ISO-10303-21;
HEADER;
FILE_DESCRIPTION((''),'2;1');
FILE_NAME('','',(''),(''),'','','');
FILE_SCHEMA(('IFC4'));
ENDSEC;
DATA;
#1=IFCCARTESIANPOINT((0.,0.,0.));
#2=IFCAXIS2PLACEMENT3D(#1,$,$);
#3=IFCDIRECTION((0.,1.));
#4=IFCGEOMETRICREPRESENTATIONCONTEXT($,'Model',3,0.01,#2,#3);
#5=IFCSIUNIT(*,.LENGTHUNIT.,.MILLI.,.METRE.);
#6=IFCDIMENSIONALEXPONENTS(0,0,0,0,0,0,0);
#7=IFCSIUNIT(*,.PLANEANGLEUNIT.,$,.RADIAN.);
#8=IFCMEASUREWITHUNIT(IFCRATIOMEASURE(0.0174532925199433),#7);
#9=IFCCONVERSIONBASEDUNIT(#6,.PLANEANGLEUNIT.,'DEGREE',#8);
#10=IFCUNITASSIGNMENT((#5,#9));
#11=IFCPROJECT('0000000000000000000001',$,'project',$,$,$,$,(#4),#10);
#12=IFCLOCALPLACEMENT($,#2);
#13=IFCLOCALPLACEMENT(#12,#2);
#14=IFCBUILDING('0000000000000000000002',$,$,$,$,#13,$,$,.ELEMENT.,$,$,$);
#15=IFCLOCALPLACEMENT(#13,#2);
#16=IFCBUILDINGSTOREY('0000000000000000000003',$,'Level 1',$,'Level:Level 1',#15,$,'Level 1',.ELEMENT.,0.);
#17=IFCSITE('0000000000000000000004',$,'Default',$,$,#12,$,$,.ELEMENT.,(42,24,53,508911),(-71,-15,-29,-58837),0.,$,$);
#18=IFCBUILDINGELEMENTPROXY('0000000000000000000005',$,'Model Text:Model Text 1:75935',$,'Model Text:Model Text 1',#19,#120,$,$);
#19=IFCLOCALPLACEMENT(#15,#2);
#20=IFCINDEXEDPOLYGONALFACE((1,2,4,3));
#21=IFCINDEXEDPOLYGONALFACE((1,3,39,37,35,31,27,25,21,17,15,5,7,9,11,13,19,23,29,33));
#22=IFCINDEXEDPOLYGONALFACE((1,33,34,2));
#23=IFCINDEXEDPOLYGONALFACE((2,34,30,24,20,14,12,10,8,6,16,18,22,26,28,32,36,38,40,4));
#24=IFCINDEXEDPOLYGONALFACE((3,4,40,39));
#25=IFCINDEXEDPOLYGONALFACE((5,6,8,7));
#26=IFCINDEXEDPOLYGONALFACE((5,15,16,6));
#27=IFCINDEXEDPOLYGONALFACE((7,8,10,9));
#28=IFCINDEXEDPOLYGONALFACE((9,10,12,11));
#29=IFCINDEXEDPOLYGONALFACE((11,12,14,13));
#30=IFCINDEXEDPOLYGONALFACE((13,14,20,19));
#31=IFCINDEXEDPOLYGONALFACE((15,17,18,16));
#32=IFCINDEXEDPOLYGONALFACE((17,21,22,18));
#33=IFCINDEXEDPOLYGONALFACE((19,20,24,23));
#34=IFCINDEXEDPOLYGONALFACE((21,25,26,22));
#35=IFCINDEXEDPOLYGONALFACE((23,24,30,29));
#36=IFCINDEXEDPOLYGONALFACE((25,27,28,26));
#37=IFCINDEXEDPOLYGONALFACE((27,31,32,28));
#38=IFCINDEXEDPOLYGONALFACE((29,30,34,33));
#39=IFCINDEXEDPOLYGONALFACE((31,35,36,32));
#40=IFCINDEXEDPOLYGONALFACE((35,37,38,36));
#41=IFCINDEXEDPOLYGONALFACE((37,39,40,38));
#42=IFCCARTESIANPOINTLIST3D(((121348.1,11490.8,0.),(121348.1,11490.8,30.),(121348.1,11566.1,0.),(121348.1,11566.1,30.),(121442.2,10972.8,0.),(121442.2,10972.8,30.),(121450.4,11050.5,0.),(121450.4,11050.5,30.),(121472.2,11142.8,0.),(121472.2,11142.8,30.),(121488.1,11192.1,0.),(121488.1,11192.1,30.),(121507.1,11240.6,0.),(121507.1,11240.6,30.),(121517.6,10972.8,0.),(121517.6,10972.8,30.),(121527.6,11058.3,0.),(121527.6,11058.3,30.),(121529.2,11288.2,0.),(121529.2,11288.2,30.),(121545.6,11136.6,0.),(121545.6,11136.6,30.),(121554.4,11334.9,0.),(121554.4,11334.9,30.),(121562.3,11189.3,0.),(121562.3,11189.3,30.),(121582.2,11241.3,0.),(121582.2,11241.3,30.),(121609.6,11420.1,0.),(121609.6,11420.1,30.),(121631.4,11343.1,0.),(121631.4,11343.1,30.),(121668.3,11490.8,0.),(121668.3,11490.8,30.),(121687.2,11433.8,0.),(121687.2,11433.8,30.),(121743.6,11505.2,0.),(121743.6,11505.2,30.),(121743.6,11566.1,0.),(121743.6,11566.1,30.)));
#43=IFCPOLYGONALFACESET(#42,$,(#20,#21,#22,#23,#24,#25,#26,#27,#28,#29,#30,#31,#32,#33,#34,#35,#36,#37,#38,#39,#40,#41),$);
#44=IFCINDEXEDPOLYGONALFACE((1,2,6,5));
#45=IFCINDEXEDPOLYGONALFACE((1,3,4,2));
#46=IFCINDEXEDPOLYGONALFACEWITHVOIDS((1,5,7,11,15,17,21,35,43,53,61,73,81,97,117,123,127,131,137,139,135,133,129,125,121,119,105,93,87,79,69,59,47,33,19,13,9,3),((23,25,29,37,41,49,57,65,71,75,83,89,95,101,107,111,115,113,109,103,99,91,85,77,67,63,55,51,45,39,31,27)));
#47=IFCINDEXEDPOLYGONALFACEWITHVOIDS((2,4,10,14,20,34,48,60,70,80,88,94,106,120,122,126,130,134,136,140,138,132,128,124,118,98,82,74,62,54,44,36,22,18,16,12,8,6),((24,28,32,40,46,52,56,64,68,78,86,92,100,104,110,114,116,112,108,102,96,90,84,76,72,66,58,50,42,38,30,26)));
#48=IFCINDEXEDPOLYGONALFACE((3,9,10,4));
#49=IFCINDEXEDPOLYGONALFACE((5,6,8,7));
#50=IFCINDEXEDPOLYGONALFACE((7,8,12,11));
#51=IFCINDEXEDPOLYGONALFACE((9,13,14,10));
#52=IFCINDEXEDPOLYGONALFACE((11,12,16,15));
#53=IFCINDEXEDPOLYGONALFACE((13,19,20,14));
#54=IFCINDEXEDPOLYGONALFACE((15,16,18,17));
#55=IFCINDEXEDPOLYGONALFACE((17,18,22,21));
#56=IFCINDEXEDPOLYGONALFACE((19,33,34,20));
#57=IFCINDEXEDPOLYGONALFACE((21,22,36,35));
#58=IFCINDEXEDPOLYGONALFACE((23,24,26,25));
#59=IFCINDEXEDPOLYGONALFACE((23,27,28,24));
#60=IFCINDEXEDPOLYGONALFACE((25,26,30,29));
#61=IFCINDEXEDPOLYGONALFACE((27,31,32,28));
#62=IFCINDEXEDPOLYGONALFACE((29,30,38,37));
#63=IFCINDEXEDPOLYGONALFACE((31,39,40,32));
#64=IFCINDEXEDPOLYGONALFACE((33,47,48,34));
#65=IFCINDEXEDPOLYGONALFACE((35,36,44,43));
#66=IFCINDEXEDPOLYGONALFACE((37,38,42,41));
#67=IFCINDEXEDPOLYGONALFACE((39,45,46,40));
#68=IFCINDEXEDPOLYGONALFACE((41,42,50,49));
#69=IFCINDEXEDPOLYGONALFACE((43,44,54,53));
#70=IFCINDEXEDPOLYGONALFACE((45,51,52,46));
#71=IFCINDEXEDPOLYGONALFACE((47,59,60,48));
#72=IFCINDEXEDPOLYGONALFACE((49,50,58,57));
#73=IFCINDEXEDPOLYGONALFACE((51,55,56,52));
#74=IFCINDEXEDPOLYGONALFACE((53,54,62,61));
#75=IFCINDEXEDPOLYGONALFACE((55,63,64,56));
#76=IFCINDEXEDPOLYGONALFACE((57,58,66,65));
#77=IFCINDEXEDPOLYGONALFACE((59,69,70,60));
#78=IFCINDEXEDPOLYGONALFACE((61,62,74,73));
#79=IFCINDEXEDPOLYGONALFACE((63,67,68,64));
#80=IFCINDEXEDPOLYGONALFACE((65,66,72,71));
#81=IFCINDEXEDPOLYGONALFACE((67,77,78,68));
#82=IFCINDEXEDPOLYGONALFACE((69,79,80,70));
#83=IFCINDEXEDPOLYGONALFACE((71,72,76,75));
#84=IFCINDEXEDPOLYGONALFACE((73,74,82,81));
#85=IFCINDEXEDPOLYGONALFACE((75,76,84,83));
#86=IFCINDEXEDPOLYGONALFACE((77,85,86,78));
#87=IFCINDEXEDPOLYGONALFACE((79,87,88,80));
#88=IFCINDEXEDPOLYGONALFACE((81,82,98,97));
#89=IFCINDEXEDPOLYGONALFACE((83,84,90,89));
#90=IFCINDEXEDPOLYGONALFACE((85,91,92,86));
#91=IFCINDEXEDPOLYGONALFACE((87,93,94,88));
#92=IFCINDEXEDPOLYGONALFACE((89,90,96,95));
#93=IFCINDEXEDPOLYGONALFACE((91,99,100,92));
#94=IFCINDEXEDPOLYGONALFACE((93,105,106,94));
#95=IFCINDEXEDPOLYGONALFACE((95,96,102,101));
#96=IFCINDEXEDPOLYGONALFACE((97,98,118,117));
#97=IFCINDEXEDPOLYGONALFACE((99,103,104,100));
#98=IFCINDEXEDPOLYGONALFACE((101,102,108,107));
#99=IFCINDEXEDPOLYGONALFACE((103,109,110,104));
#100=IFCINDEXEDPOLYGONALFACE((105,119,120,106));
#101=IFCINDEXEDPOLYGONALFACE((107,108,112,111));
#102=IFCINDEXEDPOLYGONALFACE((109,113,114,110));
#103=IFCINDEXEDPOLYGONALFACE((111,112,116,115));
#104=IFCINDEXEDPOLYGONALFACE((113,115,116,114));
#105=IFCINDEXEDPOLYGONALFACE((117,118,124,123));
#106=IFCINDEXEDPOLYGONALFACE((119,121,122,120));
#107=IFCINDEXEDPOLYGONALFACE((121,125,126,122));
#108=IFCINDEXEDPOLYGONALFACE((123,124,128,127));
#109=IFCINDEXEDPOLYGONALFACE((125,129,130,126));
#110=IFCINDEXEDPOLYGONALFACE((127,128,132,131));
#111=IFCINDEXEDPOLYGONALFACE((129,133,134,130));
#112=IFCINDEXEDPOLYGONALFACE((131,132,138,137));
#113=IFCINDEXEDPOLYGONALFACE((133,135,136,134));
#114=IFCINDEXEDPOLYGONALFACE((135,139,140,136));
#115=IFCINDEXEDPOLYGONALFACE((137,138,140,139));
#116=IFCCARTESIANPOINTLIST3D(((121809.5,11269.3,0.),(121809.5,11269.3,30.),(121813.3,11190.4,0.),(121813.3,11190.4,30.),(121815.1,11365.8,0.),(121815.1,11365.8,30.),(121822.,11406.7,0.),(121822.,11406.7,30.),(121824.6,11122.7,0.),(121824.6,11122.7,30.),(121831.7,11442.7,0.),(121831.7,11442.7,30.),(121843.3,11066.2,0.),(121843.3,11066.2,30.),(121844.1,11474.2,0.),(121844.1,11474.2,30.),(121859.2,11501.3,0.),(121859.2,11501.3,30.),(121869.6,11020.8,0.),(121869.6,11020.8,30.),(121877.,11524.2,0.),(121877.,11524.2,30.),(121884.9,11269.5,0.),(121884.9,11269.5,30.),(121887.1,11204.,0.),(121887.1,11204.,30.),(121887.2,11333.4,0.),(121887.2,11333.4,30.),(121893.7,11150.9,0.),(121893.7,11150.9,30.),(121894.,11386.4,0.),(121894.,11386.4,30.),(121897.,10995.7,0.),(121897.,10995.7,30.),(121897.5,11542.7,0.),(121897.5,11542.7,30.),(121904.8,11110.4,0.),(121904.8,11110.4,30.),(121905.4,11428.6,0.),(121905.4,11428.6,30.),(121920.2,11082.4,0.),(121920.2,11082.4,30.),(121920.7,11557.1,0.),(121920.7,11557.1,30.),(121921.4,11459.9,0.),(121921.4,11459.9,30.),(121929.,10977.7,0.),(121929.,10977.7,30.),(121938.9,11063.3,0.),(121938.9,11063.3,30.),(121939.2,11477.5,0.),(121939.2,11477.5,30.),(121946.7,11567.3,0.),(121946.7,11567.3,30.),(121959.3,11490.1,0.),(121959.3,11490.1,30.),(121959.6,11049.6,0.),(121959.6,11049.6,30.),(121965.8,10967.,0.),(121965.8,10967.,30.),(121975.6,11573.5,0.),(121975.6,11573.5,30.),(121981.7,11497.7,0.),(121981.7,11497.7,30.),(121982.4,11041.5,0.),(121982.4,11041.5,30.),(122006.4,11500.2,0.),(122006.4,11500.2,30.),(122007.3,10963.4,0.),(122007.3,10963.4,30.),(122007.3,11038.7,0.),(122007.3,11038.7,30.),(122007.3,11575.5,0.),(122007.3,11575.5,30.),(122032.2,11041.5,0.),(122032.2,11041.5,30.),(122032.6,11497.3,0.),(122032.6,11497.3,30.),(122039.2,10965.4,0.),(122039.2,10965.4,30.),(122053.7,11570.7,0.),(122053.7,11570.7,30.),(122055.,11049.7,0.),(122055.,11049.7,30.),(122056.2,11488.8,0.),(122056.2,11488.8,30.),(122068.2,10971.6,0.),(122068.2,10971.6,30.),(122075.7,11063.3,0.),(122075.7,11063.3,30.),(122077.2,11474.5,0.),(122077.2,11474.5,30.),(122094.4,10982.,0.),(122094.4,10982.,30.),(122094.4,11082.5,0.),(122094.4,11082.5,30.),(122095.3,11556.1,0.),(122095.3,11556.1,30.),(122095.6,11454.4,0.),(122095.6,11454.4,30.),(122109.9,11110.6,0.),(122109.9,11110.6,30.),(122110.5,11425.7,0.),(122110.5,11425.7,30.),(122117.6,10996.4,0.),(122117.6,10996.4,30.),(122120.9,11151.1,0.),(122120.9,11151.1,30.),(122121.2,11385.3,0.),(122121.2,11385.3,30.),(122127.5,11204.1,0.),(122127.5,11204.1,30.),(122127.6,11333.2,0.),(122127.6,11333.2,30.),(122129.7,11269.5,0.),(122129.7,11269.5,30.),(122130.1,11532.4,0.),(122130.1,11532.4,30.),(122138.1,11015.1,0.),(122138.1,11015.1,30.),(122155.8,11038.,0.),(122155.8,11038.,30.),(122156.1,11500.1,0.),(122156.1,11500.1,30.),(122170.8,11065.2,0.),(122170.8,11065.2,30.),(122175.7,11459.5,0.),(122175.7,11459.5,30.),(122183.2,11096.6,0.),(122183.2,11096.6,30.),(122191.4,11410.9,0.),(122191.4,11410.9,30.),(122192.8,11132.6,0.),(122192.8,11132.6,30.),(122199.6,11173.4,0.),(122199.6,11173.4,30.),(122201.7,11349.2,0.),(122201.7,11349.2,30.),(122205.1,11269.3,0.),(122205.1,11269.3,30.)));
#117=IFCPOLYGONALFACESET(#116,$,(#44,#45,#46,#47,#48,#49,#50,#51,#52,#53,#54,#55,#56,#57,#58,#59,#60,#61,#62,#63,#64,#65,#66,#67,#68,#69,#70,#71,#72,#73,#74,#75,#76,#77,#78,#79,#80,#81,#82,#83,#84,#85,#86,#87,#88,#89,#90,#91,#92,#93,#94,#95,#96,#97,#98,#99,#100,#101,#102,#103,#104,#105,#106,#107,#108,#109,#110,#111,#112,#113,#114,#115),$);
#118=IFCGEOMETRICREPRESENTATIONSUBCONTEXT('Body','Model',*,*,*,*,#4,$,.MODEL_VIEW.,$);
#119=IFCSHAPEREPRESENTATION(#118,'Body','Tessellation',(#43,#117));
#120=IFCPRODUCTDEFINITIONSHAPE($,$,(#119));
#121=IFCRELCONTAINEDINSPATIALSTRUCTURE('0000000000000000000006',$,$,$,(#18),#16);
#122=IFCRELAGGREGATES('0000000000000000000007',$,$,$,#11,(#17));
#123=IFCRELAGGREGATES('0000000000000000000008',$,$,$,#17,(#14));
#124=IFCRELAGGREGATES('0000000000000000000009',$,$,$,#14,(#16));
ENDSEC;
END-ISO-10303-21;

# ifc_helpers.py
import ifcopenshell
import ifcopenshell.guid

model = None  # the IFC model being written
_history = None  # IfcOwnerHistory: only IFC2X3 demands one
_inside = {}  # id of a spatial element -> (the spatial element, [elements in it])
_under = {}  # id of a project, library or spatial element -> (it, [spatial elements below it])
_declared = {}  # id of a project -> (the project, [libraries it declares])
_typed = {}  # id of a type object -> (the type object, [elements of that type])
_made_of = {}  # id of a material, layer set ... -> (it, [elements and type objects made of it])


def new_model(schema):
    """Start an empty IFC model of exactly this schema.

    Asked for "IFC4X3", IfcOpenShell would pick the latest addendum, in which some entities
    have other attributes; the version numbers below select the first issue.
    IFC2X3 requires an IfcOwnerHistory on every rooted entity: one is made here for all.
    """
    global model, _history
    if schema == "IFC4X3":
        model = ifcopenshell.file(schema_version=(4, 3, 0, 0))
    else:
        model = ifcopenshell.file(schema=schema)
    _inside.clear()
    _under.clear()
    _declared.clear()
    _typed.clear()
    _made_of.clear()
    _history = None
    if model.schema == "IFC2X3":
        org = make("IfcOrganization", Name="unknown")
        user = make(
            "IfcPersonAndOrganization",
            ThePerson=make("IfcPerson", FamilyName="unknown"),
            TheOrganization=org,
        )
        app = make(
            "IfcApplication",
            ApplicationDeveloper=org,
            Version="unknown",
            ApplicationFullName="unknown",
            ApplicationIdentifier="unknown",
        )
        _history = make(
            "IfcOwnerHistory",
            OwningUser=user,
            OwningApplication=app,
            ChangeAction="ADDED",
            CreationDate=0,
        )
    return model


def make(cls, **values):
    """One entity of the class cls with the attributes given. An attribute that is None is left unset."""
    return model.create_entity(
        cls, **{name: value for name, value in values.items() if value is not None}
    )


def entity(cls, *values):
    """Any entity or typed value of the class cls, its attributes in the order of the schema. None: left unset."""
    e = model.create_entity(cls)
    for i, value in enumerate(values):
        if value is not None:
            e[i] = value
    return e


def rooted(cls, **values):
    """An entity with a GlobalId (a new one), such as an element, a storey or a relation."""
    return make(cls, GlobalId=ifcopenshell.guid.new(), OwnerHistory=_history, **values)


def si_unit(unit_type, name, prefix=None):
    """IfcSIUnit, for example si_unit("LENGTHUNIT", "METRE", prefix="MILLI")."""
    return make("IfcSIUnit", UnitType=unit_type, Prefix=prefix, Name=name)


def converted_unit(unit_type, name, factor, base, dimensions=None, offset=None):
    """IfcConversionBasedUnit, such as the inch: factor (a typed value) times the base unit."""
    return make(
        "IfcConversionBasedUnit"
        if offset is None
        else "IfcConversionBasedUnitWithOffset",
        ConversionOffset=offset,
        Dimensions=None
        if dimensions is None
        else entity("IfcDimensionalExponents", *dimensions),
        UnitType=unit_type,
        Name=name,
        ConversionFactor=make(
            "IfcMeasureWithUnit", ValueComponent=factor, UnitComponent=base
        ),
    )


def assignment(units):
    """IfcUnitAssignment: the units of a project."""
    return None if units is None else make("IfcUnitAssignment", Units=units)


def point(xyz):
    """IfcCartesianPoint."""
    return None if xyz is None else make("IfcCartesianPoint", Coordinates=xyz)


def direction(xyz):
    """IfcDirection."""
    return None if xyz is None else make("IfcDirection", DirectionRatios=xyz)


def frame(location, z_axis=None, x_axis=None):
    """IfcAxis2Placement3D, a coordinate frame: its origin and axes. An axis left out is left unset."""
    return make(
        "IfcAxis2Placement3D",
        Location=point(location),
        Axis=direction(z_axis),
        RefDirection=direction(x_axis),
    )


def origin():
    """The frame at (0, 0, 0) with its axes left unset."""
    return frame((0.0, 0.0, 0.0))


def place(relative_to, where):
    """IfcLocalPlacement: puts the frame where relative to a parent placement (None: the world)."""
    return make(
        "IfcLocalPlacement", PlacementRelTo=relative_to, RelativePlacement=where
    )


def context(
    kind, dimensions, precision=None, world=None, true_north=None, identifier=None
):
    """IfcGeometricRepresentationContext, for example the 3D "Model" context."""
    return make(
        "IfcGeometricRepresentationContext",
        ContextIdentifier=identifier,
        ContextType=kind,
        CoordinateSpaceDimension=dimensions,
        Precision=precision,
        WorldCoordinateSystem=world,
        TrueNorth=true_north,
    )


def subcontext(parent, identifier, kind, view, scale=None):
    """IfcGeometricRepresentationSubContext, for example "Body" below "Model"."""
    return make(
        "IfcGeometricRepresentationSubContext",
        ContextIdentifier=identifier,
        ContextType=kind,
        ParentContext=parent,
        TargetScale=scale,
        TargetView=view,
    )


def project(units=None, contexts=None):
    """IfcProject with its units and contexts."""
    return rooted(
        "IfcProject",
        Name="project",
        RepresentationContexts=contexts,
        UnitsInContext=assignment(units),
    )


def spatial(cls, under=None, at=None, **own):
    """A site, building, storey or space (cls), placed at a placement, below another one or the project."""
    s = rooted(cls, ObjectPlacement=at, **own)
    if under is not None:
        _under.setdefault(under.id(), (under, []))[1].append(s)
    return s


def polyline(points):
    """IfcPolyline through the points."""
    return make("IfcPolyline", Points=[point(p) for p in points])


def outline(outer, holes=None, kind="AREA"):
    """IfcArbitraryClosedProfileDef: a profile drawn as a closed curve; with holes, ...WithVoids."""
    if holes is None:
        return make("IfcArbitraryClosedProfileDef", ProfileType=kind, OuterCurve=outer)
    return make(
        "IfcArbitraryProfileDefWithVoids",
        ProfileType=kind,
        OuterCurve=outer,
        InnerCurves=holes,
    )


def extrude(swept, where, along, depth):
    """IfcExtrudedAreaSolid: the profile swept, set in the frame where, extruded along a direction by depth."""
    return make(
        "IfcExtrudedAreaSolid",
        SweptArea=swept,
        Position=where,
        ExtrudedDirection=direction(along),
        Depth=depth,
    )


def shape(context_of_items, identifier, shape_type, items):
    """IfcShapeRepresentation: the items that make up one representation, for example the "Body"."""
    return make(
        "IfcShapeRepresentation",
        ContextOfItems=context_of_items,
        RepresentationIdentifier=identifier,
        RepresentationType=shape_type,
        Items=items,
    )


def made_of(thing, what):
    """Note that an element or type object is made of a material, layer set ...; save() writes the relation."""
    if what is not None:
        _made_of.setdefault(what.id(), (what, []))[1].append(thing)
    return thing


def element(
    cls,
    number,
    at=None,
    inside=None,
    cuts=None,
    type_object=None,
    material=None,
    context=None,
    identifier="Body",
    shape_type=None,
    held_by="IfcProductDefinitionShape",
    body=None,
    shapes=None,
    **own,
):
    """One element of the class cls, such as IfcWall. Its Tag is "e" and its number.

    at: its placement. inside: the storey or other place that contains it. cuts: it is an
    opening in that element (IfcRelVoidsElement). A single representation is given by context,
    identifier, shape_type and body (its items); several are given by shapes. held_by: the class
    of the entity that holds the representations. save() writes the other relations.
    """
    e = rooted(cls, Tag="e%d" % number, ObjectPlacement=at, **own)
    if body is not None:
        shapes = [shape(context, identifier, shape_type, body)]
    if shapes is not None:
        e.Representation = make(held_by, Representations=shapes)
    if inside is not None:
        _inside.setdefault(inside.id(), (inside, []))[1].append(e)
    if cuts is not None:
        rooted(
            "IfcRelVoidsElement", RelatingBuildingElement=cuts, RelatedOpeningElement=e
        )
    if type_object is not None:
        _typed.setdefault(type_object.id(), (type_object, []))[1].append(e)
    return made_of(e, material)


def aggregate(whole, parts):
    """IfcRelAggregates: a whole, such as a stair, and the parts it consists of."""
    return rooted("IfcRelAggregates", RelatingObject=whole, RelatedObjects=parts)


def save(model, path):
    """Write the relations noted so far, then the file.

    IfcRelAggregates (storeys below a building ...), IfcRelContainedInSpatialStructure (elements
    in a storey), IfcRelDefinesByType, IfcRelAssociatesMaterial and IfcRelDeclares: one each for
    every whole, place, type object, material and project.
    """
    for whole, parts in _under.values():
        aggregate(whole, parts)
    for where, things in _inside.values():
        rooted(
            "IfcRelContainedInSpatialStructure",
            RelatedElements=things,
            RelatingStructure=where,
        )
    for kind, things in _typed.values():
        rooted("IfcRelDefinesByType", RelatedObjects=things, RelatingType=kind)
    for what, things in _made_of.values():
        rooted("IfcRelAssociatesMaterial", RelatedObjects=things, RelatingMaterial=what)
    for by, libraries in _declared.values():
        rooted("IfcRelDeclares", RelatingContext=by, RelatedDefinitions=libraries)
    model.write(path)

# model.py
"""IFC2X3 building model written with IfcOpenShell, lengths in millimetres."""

from ifc_helpers import new_model, entity, si_unit, converted_unit, direction, frame, origin, place, context, subcontext, project, spatial, polyline, outline, extrude, element, save


model = new_model("IFC2X3")

# Units and contexts
model_context = context("Model", 3, precision=0.01, world=origin(), true_north=direction((0.0, 1.0)))
body_context = subcontext(model_context, "Body", "Model", "MODEL_VIEW")
ifc_project = project(units=[si_unit("LENGTHUNIT", "METRE", prefix="MILLI"), converted_unit("PLANEANGLEUNIT", "DEGREE", entity("IfcRatioMeasure", 0.0174532925199433), si_unit("PLANEANGLEUNIT", "RADIAN"), dimensions=[0, 0, 0, 0, 0, 0, 0])], contexts=[model_context])

# Site, building, storey
site_placement = place(None, origin())
site = spatial("IfcSite", under=ifc_project, at=site_placement, Name="Default", CompositionType="ELEMENT", RefLatitude=(42, 24, 53, 508911), RefLongitude=(-71, -15, -29, -58837), RefElevation=0.0)
building_placement = place(site_placement, origin())
building = spatial("IfcBuilding", under=site, at=building_placement, CompositionType="ELEMENT")
storey_placement = place(building_placement, origin())
storey = spatial("IfcBuildingStorey", under=building, at=storey_placement, Name="Level 1", ObjectType="Level:Level 1", LongName="Level 1", CompositionType="ELEMENT", Elevation=0.0)

# Building element proxy
proxy_1_placement = place(storey_placement, origin())
element("IfcBuildingElementProxy", 1, at=proxy_1_placement, inside=storey, Name="Model Text:Model Text 1:75935", ObjectType="Model Text:Model Text 1", context=body_context, shape_type="SweptSolid", body=[
    extrude(outline(polyline([(-199.9, -209.0), (-199.9, -284.3), (195.7, -284.3), (195.7, -223.4), (139.3, -152.0), (83.5, -61.3), (34.2, 40.5), (14.4, 92.5), (-2.4, 145.2), (-20.3, 223.5), (-30.3, 309.0), (-105.7, 309.0), (-97.5, 231.3), (-75.7, 139.0), (-59.9, 89.7), (-40.9, 41.2), (-18.8, -6.4), (6.4, -53.1), (61.7, -138.3), (120.3, -209.0), (-199.9, -209.0)])), frame((121547.9, 11281.8, 0.0), z_axis=(0.0, 0.0, -1.0), x_axis=(1.0, 0.0, 0.0)), (0.0, 0.0, -1.0), 30.0),
    extrude(outline(polyline([(-10.6, -198.7), (68.3, -198.7), (136.5, -190.7), (193.9, -174.7), (240.5, -150.6), (266.9, -124.4), (286.3, -93.2), (298.8, -57.0), (304.3, -15.7), (303.8, 16.2), (299.0, 45.5), (289.9, 72.1), (276.6, 96.0), (258.9, 117.3), (236.9, 136.2), (210.4, 152.5), (179.6, 166.3), (144.1, 177.6), (103.7, 186.3), (8.2, 196.4), (-71.8, 196.7), (-134.0, 189.4), (-183.3, 176.1), (-224.7, 158.4), (-258.2, 133.9), (-283.5, 100.3), (-300.1, 59.5), (-307.1, 13.4), (-306.6, -18.4), (-301.8, -47.5), (-292.8, -74.0), (-279.6, -97.9), (-262.0, -119.2), (-240.0, -138.1), (-213.6, -154.5), (-182.8, -168.4), (-147.3, -179.8), (-106.7, -188.6), (-10.6, -198.7)]), holes=[polyline([(-7.2, -123.5), (-71.0, -118.2), (-123.6, -108.8), (-165.2, -95.4), (-195.7, -78.0), (-212.4, -59.4), (-224.1, -38.7), (-230.6, -15.9), (-231.9, 8.9), (-227.8, 35.0), (-218.1, 58.1), (-202.8, 78.4), (-182.0, 95.8), (-152.6, 109.4), (-111.7, 118.1), (-59.4, 122.0), (4.4, 121.1), (69.6, 115.8), (122.2, 106.7), (162.2, 93.7), (189.5, 77.0), (207.7, 57.4), (220.4, 36.0), (227.5, 12.8), (229.1, -12.1), (225.2, -36.8), (215.9, -59.2), (201.3, -79.3), (181.4, -97.1), (152.6, -111.2), (111.6, -120.3), (58.3, -124.4), (-7.2, -123.5)])]), frame((122008.6, 11268.1, 0.0), z_axis=(0.0, 0.0, 1.0), x_axis=(0.047515, -0.998871, 0.0)), (0.0, 0.0, 1.0), 30.0),
])

save(model, "model.ifc")
